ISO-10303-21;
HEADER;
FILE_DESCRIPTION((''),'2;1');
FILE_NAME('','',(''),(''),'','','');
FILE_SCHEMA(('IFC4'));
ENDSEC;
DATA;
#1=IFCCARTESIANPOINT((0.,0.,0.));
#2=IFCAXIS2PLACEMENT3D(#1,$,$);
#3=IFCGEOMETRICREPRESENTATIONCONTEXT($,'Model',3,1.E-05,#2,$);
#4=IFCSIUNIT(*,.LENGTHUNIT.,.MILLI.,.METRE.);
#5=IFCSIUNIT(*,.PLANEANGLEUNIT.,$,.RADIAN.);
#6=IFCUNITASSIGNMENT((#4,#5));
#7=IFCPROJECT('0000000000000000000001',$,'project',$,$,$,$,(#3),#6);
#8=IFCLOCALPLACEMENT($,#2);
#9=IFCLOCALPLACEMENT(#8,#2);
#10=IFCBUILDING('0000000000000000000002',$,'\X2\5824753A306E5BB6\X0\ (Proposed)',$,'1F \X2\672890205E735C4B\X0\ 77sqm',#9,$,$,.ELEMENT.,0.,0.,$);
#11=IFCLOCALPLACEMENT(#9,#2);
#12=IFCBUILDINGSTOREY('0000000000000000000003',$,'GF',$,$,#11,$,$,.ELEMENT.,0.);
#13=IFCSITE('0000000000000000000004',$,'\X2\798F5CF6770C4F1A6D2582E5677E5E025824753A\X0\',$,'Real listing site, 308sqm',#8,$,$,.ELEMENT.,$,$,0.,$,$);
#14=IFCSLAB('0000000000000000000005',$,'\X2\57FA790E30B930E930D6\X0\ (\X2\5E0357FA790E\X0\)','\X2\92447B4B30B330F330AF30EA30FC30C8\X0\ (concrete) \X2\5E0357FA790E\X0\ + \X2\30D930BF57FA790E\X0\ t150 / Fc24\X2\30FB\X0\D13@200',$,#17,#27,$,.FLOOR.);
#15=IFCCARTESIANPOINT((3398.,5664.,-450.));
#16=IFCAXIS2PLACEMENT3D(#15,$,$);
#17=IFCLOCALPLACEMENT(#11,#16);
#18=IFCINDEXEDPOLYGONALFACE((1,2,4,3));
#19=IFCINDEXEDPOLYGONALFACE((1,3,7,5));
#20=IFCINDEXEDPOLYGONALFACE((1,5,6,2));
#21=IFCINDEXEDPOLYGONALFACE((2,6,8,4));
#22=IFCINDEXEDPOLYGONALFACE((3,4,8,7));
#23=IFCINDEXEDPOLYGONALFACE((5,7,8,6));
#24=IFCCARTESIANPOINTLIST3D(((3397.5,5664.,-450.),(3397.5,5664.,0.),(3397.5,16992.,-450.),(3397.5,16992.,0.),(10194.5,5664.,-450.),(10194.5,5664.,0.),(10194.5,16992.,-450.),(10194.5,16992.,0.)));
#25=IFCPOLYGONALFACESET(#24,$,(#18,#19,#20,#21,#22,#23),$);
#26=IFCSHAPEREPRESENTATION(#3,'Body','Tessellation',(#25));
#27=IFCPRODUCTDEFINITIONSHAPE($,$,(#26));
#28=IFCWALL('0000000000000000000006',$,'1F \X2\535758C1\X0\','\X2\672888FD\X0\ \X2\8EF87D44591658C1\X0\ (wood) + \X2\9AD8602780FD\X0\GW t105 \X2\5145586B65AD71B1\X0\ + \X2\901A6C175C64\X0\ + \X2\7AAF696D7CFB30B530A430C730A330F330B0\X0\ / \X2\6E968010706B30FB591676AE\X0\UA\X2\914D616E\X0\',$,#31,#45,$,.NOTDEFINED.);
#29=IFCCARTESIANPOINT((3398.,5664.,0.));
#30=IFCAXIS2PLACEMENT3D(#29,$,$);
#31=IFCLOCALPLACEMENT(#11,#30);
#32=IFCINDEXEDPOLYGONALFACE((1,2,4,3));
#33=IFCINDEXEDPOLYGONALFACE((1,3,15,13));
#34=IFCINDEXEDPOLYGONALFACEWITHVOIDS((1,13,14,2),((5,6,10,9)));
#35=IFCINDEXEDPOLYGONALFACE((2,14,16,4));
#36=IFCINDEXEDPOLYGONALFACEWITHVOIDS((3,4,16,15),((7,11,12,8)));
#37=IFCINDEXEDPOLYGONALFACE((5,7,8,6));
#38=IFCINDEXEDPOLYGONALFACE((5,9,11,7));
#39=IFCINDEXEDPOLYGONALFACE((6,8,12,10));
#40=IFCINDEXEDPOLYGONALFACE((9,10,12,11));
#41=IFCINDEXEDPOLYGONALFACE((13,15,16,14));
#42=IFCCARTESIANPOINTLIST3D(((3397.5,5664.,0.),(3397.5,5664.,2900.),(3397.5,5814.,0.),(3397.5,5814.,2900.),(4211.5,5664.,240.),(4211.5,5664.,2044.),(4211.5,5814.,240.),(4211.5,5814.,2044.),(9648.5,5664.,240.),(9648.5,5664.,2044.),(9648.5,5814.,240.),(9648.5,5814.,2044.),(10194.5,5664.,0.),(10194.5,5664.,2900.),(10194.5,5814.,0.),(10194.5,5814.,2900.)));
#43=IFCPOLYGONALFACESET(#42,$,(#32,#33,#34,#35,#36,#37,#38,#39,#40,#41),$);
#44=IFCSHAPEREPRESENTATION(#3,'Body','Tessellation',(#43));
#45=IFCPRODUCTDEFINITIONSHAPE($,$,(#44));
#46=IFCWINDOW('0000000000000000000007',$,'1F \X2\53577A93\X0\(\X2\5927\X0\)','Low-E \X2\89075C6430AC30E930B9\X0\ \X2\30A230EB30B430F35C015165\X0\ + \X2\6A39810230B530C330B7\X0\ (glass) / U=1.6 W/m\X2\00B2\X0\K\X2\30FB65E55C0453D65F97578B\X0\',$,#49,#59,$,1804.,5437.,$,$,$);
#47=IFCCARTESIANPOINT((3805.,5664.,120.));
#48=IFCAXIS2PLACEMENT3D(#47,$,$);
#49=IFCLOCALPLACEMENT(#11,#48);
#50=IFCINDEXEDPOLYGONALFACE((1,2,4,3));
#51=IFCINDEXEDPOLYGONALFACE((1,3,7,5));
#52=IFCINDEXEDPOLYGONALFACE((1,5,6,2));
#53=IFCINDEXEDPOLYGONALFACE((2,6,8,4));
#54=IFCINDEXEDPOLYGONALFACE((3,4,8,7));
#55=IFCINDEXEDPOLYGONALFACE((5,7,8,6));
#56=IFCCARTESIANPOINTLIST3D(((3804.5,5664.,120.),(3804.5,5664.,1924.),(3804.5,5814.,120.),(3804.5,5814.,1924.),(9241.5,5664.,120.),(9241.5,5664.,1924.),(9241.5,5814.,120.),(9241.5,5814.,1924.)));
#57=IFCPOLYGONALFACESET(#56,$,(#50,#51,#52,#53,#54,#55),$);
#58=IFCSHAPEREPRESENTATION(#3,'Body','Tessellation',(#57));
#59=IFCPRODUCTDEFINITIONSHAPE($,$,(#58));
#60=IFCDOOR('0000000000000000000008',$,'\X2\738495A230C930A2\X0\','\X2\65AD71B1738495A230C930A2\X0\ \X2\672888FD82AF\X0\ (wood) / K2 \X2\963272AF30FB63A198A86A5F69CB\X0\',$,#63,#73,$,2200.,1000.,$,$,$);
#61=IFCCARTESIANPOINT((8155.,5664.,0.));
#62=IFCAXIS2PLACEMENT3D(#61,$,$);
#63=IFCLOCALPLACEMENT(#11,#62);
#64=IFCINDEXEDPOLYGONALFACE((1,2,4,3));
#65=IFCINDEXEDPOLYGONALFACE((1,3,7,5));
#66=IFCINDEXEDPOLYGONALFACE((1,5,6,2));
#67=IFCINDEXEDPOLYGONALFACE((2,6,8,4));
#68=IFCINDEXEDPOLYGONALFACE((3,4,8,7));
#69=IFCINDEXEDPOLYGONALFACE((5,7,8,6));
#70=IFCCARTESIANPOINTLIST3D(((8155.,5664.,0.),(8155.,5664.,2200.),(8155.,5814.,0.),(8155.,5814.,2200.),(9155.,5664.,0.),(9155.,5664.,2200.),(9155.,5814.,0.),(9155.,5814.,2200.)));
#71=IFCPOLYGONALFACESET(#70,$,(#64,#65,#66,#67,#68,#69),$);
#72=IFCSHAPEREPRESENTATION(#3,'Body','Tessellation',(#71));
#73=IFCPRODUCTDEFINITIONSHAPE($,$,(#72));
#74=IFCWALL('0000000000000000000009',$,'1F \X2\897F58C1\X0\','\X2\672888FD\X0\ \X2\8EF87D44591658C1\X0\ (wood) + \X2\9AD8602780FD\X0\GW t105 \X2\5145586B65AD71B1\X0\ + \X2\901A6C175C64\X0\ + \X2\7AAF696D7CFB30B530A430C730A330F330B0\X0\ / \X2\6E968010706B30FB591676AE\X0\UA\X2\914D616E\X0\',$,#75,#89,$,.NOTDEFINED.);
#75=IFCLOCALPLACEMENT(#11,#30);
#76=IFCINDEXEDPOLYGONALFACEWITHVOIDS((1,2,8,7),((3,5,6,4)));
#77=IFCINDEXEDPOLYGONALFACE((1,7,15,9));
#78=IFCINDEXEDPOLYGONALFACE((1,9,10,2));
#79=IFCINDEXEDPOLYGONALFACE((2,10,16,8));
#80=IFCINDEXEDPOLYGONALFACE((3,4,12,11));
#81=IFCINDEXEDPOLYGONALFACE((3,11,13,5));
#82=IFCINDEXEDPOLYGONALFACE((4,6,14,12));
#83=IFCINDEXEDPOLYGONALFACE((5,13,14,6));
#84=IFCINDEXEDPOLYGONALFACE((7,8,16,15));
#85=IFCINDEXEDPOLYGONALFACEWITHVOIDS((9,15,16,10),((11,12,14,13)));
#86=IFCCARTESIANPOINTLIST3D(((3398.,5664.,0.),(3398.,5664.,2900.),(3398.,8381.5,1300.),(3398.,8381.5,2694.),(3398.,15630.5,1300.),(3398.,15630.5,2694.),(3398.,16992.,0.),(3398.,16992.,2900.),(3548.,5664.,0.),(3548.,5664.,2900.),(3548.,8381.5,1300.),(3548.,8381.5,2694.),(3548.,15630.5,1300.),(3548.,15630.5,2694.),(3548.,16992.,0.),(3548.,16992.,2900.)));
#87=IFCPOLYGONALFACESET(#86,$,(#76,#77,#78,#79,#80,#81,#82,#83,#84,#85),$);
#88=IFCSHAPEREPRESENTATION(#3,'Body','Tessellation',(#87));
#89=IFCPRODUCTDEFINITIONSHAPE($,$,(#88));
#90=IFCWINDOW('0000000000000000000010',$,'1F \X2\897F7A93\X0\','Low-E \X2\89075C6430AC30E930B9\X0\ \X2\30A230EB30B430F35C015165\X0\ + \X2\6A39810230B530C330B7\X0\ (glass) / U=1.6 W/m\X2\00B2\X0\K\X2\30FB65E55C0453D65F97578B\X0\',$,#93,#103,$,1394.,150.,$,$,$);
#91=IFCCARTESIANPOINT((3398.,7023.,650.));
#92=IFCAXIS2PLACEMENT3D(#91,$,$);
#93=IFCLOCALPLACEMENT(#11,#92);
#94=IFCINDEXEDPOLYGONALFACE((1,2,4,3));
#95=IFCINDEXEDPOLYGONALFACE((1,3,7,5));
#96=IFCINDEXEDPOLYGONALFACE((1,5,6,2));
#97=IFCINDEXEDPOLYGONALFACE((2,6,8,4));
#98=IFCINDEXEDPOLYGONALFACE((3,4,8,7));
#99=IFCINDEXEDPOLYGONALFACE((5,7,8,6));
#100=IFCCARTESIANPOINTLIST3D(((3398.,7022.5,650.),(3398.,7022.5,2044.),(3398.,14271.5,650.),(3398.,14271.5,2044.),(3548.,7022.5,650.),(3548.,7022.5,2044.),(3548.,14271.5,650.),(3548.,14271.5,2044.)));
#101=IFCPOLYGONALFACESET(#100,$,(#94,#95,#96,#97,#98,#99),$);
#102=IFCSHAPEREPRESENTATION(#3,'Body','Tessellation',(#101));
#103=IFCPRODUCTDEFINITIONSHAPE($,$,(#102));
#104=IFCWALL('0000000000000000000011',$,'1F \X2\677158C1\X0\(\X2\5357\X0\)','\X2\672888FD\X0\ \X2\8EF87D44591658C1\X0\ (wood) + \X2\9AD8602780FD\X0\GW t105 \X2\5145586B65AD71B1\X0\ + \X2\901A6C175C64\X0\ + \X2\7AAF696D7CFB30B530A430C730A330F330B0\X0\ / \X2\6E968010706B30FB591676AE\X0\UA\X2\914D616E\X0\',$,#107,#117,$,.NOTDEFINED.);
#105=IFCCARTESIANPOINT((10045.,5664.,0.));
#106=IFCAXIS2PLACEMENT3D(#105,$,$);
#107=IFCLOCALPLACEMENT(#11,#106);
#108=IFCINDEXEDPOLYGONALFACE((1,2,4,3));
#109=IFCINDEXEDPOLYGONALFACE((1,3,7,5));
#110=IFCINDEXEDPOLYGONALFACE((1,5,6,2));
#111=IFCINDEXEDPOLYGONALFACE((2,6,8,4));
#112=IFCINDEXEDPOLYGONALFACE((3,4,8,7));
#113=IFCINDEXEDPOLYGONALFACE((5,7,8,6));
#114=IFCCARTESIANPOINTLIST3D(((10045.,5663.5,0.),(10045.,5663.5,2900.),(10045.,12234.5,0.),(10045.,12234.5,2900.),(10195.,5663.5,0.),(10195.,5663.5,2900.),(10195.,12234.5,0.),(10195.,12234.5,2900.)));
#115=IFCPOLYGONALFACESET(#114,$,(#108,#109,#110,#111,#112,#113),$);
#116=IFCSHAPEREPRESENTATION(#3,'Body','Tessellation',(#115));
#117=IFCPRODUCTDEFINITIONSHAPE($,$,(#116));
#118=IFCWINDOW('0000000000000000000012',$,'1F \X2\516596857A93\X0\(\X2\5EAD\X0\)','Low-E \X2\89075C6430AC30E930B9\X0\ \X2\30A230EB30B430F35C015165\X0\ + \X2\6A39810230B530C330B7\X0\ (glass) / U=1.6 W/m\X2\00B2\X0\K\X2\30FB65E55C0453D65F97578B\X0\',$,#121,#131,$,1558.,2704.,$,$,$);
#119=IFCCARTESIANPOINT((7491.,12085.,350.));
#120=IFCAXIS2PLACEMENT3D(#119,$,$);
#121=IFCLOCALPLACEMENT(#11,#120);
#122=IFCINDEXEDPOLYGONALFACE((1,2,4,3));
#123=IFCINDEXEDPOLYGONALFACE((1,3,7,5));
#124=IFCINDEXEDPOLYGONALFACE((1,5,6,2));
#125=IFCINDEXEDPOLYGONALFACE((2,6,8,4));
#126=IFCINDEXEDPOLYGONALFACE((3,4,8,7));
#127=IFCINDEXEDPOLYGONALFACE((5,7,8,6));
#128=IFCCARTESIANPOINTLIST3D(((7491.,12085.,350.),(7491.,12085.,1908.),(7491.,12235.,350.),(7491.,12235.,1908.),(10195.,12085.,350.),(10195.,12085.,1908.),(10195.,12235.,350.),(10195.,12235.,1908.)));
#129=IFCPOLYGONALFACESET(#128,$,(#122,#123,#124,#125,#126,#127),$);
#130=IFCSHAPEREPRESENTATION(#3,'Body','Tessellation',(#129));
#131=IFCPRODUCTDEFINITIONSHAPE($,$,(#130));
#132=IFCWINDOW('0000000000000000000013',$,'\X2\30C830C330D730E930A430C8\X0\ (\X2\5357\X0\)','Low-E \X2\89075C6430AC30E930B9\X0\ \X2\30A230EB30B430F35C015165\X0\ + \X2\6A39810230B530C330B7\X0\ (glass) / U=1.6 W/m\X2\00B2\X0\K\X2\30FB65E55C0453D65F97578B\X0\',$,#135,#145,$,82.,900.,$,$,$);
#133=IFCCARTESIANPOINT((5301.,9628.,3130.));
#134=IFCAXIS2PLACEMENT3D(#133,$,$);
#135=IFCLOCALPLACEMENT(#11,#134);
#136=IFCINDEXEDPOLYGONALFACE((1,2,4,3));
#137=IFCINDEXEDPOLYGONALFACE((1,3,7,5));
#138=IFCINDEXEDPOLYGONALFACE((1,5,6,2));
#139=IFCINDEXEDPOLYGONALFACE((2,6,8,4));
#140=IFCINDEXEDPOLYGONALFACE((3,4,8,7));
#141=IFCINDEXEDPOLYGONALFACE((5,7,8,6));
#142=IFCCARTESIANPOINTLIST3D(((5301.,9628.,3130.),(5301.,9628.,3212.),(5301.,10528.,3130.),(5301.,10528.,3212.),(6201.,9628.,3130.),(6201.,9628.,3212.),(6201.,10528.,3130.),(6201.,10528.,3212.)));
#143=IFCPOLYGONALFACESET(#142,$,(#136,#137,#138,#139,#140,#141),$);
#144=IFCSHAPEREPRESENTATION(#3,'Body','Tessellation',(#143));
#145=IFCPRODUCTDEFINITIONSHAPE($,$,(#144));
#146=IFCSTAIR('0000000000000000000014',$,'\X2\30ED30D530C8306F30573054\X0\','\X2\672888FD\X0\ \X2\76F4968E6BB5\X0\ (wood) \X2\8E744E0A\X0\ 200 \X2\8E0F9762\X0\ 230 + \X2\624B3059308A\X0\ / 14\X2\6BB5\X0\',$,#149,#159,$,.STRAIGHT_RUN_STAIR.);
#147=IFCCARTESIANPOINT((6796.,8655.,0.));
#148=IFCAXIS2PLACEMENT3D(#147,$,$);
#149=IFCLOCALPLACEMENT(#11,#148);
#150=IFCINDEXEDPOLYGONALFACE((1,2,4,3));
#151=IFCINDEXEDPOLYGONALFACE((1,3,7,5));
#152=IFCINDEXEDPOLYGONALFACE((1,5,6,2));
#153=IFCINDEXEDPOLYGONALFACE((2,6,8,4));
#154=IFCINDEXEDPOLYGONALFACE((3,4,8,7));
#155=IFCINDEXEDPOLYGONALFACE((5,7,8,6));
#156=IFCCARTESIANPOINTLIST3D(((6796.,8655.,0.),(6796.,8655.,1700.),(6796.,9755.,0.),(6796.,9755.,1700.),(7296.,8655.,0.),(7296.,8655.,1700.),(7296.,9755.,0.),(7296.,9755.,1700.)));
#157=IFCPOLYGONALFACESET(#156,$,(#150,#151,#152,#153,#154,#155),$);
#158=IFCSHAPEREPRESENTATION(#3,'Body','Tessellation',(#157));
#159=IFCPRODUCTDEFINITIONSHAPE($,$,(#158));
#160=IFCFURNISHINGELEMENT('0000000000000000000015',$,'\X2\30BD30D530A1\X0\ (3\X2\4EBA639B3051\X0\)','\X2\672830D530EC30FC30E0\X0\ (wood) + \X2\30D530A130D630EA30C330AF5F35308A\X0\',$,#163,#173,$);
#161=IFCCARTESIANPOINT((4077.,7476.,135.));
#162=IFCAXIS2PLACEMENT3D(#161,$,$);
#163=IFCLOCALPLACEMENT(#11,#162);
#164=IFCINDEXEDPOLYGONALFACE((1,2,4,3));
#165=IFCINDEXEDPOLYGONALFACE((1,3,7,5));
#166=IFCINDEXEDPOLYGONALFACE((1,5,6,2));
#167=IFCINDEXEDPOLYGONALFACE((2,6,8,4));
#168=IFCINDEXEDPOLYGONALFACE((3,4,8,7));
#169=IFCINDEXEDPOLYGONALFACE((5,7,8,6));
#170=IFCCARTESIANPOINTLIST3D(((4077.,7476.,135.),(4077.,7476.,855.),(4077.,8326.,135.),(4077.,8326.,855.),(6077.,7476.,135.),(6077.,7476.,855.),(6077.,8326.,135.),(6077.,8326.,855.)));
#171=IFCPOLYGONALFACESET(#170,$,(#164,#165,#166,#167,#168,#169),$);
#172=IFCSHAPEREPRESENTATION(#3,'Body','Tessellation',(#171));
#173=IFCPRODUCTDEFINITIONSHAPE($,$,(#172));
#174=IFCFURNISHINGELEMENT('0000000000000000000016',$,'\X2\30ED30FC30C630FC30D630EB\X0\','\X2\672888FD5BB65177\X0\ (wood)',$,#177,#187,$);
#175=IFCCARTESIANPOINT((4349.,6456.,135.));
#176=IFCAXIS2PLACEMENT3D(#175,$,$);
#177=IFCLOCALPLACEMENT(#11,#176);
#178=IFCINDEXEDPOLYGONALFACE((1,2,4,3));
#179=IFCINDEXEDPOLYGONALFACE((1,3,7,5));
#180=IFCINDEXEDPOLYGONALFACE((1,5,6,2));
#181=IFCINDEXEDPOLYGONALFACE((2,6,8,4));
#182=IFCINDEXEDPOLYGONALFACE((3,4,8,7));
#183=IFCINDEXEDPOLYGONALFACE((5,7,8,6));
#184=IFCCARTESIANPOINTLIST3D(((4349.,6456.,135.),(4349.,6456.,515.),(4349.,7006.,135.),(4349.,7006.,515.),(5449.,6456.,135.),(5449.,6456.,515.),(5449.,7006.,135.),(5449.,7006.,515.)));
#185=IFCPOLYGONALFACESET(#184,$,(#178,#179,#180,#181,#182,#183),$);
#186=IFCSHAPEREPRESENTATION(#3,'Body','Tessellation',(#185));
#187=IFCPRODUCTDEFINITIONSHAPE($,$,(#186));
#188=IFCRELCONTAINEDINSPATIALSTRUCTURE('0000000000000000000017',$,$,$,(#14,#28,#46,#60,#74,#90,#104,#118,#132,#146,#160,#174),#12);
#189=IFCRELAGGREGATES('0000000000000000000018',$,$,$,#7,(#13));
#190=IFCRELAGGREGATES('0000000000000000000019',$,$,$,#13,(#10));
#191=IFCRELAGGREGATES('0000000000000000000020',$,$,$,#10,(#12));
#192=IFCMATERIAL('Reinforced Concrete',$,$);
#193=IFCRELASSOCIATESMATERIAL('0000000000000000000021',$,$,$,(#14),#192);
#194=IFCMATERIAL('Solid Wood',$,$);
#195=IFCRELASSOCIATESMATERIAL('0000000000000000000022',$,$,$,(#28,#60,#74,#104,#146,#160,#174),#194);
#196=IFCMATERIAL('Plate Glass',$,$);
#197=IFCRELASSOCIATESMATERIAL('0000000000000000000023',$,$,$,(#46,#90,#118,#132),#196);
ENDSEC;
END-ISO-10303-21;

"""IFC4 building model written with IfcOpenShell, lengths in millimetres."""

from ifc_helpers import new_model, si_unit, frame, frame_2d, origin, place, context, project, spatial, rectangle, extrude, material, element, fill, save


model = new_model("IFC4")

# Units and contexts
model_context = context("Model", 3, precision=1e-05, world=origin())
ifc_project = project(units=[si_unit("LENGTHUNIT", "METRE", prefix="MILLI"), si_unit("PLANEANGLEUNIT", "RADIAN")], contexts=[model_context])

# Site, building, storey
site_placement = place(None, origin())
site = spatial("IfcSite", under=ifc_project, at=site_placement, Name="福島県会津若松市堤町", ObjectType="Real listing site, 308sqm", CompositionType="ELEMENT", RefElevation=0.0)
building_placement = place(site_placement, origin())
building = spatial("IfcBuilding", under=site, at=building_placement, Name="堤町の家 (Proposed)", ObjectType="1F 木造平屋 77sqm", CompositionType="ELEMENT", ElevationOfRefHeight=0.0, ElevationOfTerrain=0.0)
storey_placement = place(building_placement, origin())
storey = spatial("IfcBuildingStorey", under=building, at=storey_placement, Name="GF", CompositionType="ELEMENT", Elevation=0.0)

# Slab
ifc_material_1 = material(Name="Reinforced Concrete")
slab_1_placement = place(storey_placement, frame((3398.0, 5664.0, -450.0)))
element("IfcSlab", 1, at=slab_1_placement, inside=storey, material=ifc_material_1, Name="基礎スラブ (布基礎)", Description="鉄筋コンクリート (concrete) 布基礎 + ベタ基礎 t150 / Fc24・D13@200", PredefinedType="FLOOR", context=model_context, shape_type="SweptSolid", body=[
    extrude(rectangle(XDim=6797.0, YDim=11328.0, at=frame_2d((3398.0, 5664.0))), frame((3398.0, 5664.0, -450.0)), (0.0, 0.0, 1.0), 450.0),
])
ifc_material_2 = material(Name="Solid Wood")

# Wall, openings, window, door
wall_1_placement = place(storey_placement, frame((3398.0, 5664.0, 0.0)))
wall_1 = element("IfcWall", 2, at=wall_1_placement, inside=storey, material=ifc_material_2, Name="1F 南壁", Description="木製 軸組外壁 (wood) + 高性能GW t105 充填断熱 + 通気層 + 窯業系サイディング / 準耐火・外皮UA配慮", PredefinedType="NOTDEFINED", context=model_context, shape_type="SweptSolid", body=[
    extrude(rectangle(XDim=6797.0, YDim=150.0, at=frame_2d((3398.0, 75.0))), frame((3398.0, 5664.0, 0.0)), (0.0, 0.0, 1.0), 2900.0),
])
opening_1_placement = place(storey_placement, frame((3805.0, 5664.0, 120.0)))
opening_1 = element("IfcOpeningElement", 3, at=opening_1_placement, cuts=wall_1, PredefinedType="NOTDEFINED", context=model_context, shape_type="SweptSolid", body=[
    extrude(rectangle(XDim=5437.0, YDim=150.0, at=frame_2d((2718.0, 75.0))), frame((3805.0, 5664.0, 120.0)), (0.0, 0.0, 1.0), 1804.0),
])
opening_2_placement = place(storey_placement, frame((8155.0, 5664.0, 0.0)))
opening_2 = element("IfcOpeningElement", 4, at=opening_2_placement, cuts=wall_1, PredefinedType="NOTDEFINED", context=model_context, shape_type="SweptSolid", body=[
    extrude(rectangle(XDim=1000.0, YDim=150.0, at=frame_2d((500.0, 75.0))), frame((8155.0, 5664.0, 0.0)), (0.0, 0.0, 1.0), 2200.0),
])
ifc_material_3 = material(Name="Plate Glass")
window_1_placement = place(storey_placement, frame((3805.0, 5664.0, 120.0)))
window_1 = element("IfcWindow", 5, at=window_1_placement, inside=storey, material=ifc_material_3, Name="1F 南窓(大)", Description="Low-E 複層ガラス アルゴン封入 + 樹脂サッシ (glass) / U=1.6 W/m²K・日射取得型", OverallHeight=1804.0, OverallWidth=5437.0, context=model_context, shape_type="SweptSolid", body=[
    extrude(rectangle(XDim=5437.0, YDim=150.0, at=frame_2d((2718.0, 75.0))), frame((3805.0, 5664.0, 120.0)), (0.0, 0.0, 1.0), 1804.0),
])
fill(opening_1, window_1)
door_1_placement = place(storey_placement, frame((8155.0, 5664.0, 0.0)))
door_1 = element("IfcDoor", 6, at=door_1_placement, inside=storey, material=ifc_material_2, Name="玄関ドア", Description="断熱玄関ドア 木製芯 (wood) / K2 防犯・採風機構", OverallHeight=2200.0, OverallWidth=1000.0, context=model_context, shape_type="SweptSolid", body=[
    extrude(rectangle(XDim=1000.0, YDim=150.0, at=frame_2d((500.0, 75.0))), frame((8155.0, 5664.0, 0.0)), (0.0, 0.0, 1.0), 2200.0),
])
fill(opening_2, door_1)

# Walls, openings, windows
wall_2_placement = place(storey_placement, frame((3398.0, 5664.0, 0.0)))
wall_2 = element("IfcWall", 7, at=wall_2_placement, inside=storey, material=ifc_material_2, Name="1F 西壁", Description="木製 軸組外壁 (wood) + 高性能GW t105 充填断熱 + 通気層 + 窯業系サイディング / 準耐火・外皮UA配慮", PredefinedType="NOTDEFINED", context=model_context, shape_type="SweptSolid", body=[
    extrude(rectangle(XDim=150.0, YDim=11328.0, at=frame_2d((75.0, 5664.0))), frame((3398.0, 5664.0, 0.0)), (0.0, 0.0, 1.0), 2900.0),
])
opening_3_placement = place(storey_placement, frame((3398.0, 7023.0, 650.0)))
opening_3 = element("IfcOpeningElement", 8, at=opening_3_placement, cuts=wall_2, PredefinedType="NOTDEFINED", context=model_context, shape_type="SweptSolid", body=[
    extrude(rectangle(XDim=150.0, YDim=7249.0, at=frame_2d((75.0, 3624.0))), frame((3398.0, 7023.0, 650.0)), (0.0, 0.0, 1.0), 1394.0),
])
window_2_placement = place(storey_placement, frame((3398.0, 7023.0, 650.0)))
window_2 = element("IfcWindow", 9, at=window_2_placement, inside=storey, material=ifc_material_3, Name="1F 西窓", Description="Low-E 複層ガラス アルゴン封入 + 樹脂サッシ (glass) / U=1.6 W/m²K・日射取得型", OverallHeight=1394.0, OverallWidth=150.0, context=model_context, shape_type="SweptSolid", body=[
    extrude(rectangle(XDim=150.0, YDim=7249.0, at=frame_2d((75.0, 3624.0))), frame((3398.0, 7023.0, 650.0)), (0.0, 0.0, 1.0), 1394.0),
])
fill(opening_3, window_2)
wall_3_placement = place(storey_placement, frame((10045.0, 5664.0, 0.0)))
wall_3 = element("IfcWall", 10, at=wall_3_placement, inside=storey, material=ifc_material_2, Name="1F 東壁(南)", Description="木製 軸組外壁 (wood) + 高性能GW t105 充填断熱 + 通気層 + 窯業系サイディング / 準耐火・外皮UA配慮", PredefinedType="NOTDEFINED", context=model_context, shape_type="SweptSolid", body=[
    extrude(rectangle(XDim=150.0, YDim=6571.0, at=frame_2d((75.0, 3285.0))), frame((10045.0, 5664.0, 0.0)), (0.0, 0.0, 1.0), 2900.0),
])
opening_4_placement = place(storey_placement, frame((7491.0, 12085.0, 350.0)))
opening_4 = element("IfcOpeningElement", 11, at=opening_4_placement, cuts=wall_3, PredefinedType="NOTDEFINED", context=model_context, shape_type="SweptSolid", body=[
    extrude(rectangle(XDim=2704.0, YDim=150.0, at=frame_2d((1352.0, 75.0))), frame((7491.0, 12085.0, 350.0)), (0.0, 0.0, 1.0), 1558.0),
])
window_3_placement = place(storey_placement, frame((7491.0, 12085.0, 350.0)))
window_3 = element("IfcWindow", 12, at=window_3_placement, inside=storey, material=ifc_material_3, Name="1F 入隅窓(庭)", Description="Low-E 複層ガラス アルゴン封入 + 樹脂サッシ (glass) / U=1.6 W/m²K・日射取得型", OverallHeight=1558.0, OverallWidth=2704.0, context=model_context, shape_type="SweptSolid", body=[
    extrude(rectangle(XDim=2704.0, YDim=150.0, at=frame_2d((1352.0, 75.0))), frame((7491.0, 12085.0, 350.0)), (0.0, 0.0, 1.0), 1558.0),
])
fill(opening_4, window_3)

# Window
window_4_placement = place(storey_placement, frame((5301.0, 9628.0, 3130.0)))
element("IfcWindow", 13, at=window_4_placement, inside=storey, material=ifc_material_3, Name="トップライト (南)", Description="Low-E 複層ガラス アルゴン封入 + 樹脂サッシ (glass) / U=1.6 W/m²K・日射取得型", OverallHeight=82.0, OverallWidth=900.0, context=model_context, shape_type="SweptSolid", body=[
    extrude(rectangle(XDim=900.0, YDim=900.0, at=frame_2d((450.0, 450.0))), frame((5301.0, 9628.0, 3130.0)), (0.0, 0.0, 1.0), 82.0),
])

# Stair
stair_placement = place(storey_placement, frame((6796.0, 8655.0, 0.0)))
element("IfcStair", 14, at=stair_placement, inside=storey, material=ifc_material_2, Name="ロフトはしご", Description="木製 直階段 (wood) 蹴上 200 踏面 230 + 手すり / 14段", PredefinedType="STRAIGHT_RUN_STAIR", context=model_context, shape_type="SweptSolid", body=[
    extrude(rectangle(XDim=500.0, YDim=1100.0, at=frame_2d((250.0, 550.0))), frame((6796.0, 8655.0, 0.0)), (0.0, 0.0, 1.0), 1700.0),
])

# Furnishing elements
furnishing_1_placement = place(storey_placement, frame((4077.0, 7476.0, 135.0)))
element("IfcFurnishingElement", 15, at=furnishing_1_placement, inside=storey, material=ifc_material_2, Name="ソファ (3人掛け)", Description="木フレーム (wood) + ファブリック張り", context=model_context, shape_type="SweptSolid", body=[
    extrude(rectangle(XDim=2000.0, YDim=850.0, at=frame_2d((1000.0, 425.0))), frame((4077.0, 7476.0, 135.0)), (0.0, 0.0, 1.0), 720.0),
])
furnishing_2_placement = place(storey_placement, frame((4349.0, 6456.0, 135.0)))
element("IfcFurnishingElement", 16, at=furnishing_2_placement, inside=storey, material=ifc_material_2, Name="ローテーブル", Description="木製家具 (wood)", context=model_context, shape_type="SweptSolid", body=[
    extrude(rectangle(XDim=1100.0, YDim=550.0, at=frame_2d((550.0, 275.0))), frame((4349.0, 6456.0, 135.0)), (0.0, 0.0, 1.0), 380.0),
])

save(model, "model.ifc")
